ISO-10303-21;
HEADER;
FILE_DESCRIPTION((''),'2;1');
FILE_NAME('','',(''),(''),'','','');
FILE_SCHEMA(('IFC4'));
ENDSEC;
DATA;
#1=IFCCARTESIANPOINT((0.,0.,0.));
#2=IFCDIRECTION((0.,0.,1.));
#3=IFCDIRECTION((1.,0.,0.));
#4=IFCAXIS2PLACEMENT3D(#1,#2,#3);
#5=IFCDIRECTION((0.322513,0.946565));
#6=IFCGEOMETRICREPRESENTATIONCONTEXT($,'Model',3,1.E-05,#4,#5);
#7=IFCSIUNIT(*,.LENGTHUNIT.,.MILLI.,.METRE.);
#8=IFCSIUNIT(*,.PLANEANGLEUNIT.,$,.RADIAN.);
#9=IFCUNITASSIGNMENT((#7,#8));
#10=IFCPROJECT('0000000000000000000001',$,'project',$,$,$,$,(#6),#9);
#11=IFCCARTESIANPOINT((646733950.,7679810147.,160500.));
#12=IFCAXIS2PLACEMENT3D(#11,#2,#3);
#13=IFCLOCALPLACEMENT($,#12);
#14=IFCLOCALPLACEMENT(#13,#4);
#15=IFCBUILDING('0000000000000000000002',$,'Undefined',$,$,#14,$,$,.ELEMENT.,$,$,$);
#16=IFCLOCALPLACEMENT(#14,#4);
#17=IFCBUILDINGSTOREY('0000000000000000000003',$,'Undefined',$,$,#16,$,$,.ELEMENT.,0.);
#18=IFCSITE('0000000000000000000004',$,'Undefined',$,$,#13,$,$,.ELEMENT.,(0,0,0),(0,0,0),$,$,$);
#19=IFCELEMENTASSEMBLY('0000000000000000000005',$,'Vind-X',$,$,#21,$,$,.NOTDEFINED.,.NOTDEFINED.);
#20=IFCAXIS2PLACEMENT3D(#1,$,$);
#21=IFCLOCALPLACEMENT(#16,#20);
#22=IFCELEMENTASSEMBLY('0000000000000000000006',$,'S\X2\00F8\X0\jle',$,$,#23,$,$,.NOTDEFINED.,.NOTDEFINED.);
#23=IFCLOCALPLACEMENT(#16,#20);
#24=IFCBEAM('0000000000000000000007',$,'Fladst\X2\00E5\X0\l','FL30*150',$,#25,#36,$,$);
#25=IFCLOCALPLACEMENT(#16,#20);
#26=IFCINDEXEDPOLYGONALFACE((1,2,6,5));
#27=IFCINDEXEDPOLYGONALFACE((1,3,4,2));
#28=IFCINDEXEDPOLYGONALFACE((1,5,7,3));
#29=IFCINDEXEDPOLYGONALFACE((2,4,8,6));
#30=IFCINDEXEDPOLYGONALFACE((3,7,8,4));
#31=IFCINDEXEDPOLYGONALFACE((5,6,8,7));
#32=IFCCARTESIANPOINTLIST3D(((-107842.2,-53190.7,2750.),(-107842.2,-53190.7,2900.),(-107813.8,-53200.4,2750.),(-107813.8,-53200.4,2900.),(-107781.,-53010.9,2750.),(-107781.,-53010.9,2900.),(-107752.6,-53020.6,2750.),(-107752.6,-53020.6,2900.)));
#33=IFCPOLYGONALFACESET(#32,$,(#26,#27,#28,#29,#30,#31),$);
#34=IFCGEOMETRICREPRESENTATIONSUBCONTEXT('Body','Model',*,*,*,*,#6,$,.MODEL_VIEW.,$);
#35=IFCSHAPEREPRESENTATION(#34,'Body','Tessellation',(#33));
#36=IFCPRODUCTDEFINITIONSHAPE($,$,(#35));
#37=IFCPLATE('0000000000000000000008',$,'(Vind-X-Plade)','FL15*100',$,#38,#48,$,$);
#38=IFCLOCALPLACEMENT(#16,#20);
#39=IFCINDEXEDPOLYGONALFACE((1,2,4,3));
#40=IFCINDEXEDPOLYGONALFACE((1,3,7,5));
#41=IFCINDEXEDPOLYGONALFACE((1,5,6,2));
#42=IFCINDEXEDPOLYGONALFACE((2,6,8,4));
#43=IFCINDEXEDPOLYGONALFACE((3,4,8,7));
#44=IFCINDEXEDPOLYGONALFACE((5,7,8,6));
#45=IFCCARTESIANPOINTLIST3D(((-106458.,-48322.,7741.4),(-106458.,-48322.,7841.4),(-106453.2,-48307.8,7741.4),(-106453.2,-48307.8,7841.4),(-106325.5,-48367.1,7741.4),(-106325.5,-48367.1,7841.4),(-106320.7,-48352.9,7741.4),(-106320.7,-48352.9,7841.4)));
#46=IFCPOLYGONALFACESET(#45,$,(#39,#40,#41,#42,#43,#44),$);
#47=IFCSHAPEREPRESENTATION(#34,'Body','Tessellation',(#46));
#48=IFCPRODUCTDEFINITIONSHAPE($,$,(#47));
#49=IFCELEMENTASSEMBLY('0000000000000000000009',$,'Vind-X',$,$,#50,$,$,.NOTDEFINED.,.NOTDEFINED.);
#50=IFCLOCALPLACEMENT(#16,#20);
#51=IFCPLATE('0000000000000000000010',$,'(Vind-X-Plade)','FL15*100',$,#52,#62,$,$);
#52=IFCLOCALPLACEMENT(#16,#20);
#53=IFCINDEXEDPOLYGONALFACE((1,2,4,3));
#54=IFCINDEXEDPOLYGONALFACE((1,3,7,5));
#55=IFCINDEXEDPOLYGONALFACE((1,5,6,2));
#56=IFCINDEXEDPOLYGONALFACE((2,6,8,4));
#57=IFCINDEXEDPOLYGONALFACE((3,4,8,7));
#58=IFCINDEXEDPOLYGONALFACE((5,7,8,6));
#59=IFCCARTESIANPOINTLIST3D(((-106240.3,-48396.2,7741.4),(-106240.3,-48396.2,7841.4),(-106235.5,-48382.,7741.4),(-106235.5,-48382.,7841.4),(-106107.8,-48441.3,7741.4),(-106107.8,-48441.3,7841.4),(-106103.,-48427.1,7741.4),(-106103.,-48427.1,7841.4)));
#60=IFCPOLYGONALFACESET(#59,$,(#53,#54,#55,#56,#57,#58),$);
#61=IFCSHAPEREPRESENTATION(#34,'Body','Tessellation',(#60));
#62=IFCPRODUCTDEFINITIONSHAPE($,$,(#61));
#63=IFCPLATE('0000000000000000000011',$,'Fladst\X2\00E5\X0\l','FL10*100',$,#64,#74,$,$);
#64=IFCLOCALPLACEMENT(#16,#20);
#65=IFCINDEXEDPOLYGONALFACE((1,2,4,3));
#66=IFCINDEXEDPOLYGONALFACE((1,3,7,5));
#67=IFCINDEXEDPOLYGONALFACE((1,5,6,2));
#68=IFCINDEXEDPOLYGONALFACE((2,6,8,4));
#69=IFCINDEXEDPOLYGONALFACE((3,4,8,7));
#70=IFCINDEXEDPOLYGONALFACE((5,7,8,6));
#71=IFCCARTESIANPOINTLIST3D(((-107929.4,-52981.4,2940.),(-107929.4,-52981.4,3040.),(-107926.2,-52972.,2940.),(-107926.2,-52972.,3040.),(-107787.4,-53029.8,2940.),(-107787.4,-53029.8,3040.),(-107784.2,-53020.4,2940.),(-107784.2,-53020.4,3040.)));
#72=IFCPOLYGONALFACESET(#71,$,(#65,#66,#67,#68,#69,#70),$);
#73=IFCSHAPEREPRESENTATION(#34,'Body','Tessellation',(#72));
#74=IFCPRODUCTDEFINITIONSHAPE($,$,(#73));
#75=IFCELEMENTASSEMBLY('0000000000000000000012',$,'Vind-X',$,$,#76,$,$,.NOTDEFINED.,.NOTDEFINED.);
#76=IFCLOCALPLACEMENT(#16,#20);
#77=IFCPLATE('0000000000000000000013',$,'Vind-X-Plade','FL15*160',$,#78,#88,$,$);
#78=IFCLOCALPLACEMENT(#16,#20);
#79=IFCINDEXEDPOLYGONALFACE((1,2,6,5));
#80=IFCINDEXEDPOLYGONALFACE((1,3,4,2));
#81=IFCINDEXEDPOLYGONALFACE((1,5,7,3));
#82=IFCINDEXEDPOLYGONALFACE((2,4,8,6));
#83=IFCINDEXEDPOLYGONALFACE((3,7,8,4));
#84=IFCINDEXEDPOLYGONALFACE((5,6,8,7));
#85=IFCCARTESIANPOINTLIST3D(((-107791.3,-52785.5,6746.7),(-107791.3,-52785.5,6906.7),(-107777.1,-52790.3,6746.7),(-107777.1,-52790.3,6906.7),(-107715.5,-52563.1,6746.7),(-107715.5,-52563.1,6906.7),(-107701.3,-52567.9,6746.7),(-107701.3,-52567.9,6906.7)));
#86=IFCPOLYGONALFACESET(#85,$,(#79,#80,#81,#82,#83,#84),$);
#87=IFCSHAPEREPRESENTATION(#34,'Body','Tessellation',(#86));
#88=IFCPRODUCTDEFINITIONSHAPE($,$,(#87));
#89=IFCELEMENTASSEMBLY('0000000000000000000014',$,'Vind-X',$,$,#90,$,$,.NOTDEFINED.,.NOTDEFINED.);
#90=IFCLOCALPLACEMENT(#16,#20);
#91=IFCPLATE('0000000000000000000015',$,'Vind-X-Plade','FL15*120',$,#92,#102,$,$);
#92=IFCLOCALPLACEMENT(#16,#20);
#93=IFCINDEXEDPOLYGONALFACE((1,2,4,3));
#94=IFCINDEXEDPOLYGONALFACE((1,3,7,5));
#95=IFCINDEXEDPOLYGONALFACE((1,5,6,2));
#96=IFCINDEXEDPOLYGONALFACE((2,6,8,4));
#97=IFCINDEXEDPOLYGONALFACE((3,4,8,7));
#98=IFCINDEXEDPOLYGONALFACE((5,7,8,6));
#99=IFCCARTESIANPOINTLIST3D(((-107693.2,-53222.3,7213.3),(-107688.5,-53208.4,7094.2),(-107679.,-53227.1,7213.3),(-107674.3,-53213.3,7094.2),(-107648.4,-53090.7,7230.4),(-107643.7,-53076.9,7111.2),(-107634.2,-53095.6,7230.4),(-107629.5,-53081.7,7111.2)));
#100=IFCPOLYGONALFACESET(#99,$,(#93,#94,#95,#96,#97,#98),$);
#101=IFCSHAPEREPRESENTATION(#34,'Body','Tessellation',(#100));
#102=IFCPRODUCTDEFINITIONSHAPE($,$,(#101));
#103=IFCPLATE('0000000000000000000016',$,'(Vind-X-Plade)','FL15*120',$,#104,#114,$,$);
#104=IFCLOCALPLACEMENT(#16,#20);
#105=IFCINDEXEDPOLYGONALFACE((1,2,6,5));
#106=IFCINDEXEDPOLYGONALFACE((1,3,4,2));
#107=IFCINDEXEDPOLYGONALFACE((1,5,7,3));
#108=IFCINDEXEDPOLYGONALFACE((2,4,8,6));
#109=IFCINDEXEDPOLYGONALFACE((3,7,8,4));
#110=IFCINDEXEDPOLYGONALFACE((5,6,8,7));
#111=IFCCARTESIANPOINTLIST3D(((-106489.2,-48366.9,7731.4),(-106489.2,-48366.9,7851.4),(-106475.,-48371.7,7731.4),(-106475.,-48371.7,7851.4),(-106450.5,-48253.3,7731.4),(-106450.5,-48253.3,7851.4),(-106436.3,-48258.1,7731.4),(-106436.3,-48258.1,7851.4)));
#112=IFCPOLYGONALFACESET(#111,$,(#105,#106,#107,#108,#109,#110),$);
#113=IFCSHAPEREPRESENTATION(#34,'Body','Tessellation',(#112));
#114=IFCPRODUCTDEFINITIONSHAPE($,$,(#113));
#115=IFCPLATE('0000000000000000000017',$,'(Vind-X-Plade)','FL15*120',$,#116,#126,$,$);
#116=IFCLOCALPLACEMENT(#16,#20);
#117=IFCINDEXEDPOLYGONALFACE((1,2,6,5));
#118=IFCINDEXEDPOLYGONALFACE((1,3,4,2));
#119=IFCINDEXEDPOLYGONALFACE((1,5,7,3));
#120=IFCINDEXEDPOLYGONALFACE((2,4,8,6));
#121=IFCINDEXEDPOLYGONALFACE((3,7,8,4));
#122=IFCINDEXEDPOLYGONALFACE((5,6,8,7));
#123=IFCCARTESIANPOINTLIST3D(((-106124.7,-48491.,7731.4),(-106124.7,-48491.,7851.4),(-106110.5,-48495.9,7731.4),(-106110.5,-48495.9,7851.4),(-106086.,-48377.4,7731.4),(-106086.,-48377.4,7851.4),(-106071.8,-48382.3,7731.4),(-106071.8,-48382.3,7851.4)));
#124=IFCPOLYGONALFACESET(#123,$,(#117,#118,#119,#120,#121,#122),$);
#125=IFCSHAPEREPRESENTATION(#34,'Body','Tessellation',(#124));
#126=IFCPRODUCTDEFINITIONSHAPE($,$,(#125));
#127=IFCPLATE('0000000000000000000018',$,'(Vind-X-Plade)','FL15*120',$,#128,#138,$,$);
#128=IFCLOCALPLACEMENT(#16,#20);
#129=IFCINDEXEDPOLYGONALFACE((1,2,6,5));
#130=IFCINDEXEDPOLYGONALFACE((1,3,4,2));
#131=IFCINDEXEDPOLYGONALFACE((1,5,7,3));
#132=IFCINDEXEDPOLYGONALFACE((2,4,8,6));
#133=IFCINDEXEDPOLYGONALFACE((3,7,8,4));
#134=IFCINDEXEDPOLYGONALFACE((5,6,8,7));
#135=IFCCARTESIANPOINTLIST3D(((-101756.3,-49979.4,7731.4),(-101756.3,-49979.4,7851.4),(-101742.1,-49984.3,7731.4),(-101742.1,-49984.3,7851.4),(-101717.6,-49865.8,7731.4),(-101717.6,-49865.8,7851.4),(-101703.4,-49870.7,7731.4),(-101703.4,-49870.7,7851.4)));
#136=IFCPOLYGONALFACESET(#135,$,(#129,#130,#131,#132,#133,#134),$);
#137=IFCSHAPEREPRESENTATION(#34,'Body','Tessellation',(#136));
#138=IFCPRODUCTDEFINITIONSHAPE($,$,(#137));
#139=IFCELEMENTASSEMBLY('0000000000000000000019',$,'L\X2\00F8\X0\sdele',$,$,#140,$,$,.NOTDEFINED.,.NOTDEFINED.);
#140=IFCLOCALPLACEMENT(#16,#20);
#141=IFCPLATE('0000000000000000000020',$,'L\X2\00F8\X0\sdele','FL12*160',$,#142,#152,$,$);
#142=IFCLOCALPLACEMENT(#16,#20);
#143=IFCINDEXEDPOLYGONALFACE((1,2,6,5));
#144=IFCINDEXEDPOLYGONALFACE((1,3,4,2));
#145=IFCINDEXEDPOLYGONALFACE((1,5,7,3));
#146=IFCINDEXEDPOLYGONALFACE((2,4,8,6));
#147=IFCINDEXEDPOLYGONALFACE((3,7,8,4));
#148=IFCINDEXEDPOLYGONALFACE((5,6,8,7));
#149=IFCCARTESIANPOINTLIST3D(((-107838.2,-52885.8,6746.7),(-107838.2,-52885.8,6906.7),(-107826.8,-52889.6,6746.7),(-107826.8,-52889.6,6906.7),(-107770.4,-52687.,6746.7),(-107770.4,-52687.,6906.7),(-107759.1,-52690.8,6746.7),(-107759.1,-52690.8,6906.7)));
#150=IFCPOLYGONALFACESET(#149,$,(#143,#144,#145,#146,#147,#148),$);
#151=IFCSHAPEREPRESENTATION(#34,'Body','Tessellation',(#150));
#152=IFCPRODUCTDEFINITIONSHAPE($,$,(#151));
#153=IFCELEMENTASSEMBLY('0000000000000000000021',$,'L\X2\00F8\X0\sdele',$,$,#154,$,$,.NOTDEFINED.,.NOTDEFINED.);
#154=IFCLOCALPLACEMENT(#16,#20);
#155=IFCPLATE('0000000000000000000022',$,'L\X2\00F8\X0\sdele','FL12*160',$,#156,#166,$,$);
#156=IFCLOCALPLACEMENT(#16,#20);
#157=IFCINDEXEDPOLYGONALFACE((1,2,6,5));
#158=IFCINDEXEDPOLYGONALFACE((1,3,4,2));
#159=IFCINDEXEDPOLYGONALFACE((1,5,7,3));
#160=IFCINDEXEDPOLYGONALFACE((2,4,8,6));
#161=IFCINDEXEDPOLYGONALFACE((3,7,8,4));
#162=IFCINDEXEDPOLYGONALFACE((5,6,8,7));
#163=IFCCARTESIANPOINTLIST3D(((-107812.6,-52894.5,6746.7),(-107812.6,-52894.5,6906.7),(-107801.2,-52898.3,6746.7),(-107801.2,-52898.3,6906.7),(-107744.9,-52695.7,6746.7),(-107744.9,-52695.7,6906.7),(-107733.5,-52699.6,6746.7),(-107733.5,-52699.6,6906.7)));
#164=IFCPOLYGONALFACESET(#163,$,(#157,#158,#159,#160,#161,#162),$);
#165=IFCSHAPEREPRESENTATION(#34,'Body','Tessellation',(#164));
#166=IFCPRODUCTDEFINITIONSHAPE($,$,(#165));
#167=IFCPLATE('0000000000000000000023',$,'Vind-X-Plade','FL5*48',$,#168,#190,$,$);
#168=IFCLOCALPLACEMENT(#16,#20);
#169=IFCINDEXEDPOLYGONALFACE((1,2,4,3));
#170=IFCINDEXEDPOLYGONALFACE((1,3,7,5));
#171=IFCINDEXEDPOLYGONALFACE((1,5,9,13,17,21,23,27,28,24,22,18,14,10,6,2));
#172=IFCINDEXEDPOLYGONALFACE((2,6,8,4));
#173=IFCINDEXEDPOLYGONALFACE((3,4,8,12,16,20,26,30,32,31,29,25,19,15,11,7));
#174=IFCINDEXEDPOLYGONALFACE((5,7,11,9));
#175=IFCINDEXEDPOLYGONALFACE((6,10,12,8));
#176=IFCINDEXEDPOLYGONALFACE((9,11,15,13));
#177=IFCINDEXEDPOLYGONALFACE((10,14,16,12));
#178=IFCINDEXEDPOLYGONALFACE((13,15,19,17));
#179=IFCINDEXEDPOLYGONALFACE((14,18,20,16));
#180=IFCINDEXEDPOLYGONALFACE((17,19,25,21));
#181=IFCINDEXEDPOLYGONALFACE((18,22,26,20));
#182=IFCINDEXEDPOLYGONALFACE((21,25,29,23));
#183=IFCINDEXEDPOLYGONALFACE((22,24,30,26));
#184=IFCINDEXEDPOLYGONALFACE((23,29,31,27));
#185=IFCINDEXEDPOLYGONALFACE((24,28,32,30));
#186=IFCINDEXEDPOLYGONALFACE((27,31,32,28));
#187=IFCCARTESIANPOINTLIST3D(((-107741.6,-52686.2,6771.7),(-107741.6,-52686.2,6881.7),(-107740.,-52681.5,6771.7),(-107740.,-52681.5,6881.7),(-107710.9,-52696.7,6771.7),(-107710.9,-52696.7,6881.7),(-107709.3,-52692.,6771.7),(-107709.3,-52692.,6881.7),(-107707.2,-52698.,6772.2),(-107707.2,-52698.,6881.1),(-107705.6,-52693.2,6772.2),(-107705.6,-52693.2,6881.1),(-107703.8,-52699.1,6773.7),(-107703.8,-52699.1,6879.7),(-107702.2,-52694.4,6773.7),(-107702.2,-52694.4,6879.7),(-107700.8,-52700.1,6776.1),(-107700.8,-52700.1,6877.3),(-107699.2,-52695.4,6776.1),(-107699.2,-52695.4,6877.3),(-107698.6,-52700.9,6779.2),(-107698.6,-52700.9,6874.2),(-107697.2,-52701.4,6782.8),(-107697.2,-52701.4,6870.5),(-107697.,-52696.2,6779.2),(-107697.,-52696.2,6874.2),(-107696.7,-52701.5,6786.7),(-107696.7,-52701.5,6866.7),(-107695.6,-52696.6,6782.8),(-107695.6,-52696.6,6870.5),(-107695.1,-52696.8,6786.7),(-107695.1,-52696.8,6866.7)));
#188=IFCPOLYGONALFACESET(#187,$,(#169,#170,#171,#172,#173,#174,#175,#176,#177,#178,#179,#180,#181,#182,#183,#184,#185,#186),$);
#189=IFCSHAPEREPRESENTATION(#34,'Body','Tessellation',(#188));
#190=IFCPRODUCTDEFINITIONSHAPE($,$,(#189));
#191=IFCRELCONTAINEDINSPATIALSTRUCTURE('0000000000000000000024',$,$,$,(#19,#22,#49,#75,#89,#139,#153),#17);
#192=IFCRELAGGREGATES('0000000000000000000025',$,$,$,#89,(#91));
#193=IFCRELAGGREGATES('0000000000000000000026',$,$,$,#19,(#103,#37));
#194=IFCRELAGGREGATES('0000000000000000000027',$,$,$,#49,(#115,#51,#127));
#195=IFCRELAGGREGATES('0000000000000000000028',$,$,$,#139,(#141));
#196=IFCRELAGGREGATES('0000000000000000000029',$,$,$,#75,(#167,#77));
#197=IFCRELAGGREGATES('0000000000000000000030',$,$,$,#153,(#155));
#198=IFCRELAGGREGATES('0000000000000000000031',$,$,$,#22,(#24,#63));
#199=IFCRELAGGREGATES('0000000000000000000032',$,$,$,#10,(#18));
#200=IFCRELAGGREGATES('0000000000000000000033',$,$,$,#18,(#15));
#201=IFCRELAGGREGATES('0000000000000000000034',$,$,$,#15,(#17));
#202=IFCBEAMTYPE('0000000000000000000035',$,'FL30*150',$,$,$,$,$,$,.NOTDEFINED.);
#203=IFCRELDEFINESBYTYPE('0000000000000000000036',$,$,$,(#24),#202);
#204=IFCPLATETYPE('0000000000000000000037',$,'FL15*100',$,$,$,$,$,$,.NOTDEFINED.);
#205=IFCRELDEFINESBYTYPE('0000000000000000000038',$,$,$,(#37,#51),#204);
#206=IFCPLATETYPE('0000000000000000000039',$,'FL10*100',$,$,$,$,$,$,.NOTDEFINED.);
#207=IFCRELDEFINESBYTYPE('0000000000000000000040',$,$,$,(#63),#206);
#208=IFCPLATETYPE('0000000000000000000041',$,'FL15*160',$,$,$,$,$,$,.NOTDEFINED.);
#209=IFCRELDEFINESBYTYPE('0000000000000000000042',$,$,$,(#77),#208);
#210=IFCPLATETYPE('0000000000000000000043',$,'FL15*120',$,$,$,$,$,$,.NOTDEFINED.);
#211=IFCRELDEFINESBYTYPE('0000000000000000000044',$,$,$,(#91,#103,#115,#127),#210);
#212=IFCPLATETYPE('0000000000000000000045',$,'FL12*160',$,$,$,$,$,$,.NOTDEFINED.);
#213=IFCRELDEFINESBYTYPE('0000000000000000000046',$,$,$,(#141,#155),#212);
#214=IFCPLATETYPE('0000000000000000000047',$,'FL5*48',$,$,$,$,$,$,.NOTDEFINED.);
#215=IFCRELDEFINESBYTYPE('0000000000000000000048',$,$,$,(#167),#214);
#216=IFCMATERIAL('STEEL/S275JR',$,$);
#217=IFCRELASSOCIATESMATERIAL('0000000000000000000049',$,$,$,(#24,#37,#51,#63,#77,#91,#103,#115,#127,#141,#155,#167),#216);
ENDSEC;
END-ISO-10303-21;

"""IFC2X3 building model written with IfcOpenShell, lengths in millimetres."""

from ifc_helpers import new_model, si_unit, direction, frame, frame_2d, origin_with_axes, origin_2d_with_axis, place, context, subcontext, project, spatial, polyline, circle_curve, parameter, trimmed, segment, composite_curve, rectangle, outline, extrude, material, type_object, element, aggregate, save


model = new_model("IFC2X3")

# Units and contexts
model_context = context("Model", 3, precision=1e-05, world=origin_with_axes(), true_north=direction((0.322513, 0.946565)))
body_context = subcontext(model_context, "Body", "Model", "MODEL_VIEW")
ifc_project = project(units=[si_unit("LENGTHUNIT", "METRE", prefix="MILLI"), si_unit("PLANEANGLEUNIT", "RADIAN")], contexts=[model_context])

# Site, building, storey
site_placement = place(None, frame((646733950.0, 7679810147.0, 160500.0), z_axis=(0.0, 0.0, 1.0), x_axis=(1.0, 0.0, 0.0)))
site = spatial("IfcSite", under=ifc_project, at=site_placement, Name="Undefined", CompositionType="ELEMENT", RefLatitude=(0, 0, 0), RefLongitude=(0, 0, 0))
building_placement = place(site_placement, origin_with_axes())
building = spatial("IfcBuilding", under=site, at=building_placement, Name="Undefined", CompositionType="ELEMENT")
storey_placement = place(building_placement, origin_with_axes())
storey = spatial("IfcBuildingStorey", under=building, at=storey_placement, Name="Undefined", CompositionType="ELEMENT", Elevation=0.0)

# Element assemblies, beam
assembly_1_placement = place(storey_placement, origin_with_axes())
assembly_1 = element("IfcElementAssembly", 1, at=assembly_1_placement, inside=storey, Name="Vind-X", AssemblyPlace="NOTDEFINED", PredefinedType="NOTDEFINED")
assembly_2_placement = place(storey_placement, origin_with_axes())
assembly_2 = element("IfcElementAssembly", 2, at=assembly_2_placement, inside=storey, Name="Søjle", AssemblyPlace="NOTDEFINED", PredefinedType="NOTDEFINED")
ifc_material_1 = material(Name="STEEL/S275JR")
beam_type_1 = type_object("IfcBeamType", Name="FL30*150", PredefinedType="NOTDEFINED")
beam_1_placement = place(assembly_2_placement, frame((-107797.4, -53105.6, 2900.0), z_axis=(-0.322513, -0.946565, 0.0), x_axis=(0.0, 0.0, -1.0)))
beam_1 = element("IfcBeam", 3, at=beam_1_placement, type_object=beam_type_1, material=ifc_material_1, Name="Fladstål", Description="FL30*150", context=body_context, shape_type="SweptSolid", body=[
    extrude(rectangle(XDim=30.0, YDim=190.0, at=origin_2d_with_axis()), frame((150.0, 0.0, 0.0), z_axis=(-1.0, 0.0, 0.0), x_axis=(0.0, -1.0, 0.0)), (0.0, 0.0, 1.0), 150.0),
])

# Plate
plate_type_1 = type_object("IfcPlateType", Name="FL15*100", PredefinedType="NOTDEFINED")
plate_1_placement = place(assembly_1_placement, frame((-106323.1, -48360.0, 7741.4), z_axis=(-0.322513, -0.946565, 0.0), x_axis=(0.0, 0.0, 1.0)))
plate_1 = element("IfcPlate", 4, at=plate_1_placement, type_object=plate_type_1, material=ifc_material_1, Name="(Vind-X-Plade)", Description="FL15*100", context=body_context, shape_type="SweptSolid", body=[
    extrude(outline(polyline([(0.0, 0.0), (100.0, 0.0), (100.0, 140.0), (0.0, 140.0), (0.0, 0.0)])), frame((0.0, 0.0, -7.5), z_axis=(0.0, 0.0, 1.0), x_axis=(1.0, 0.0, 0.0)), (0.0, 0.0, 1.0), 15.0),
])

# Element assembly, plate
assembly_3_placement = place(storey_placement, origin_with_axes())
assembly_3 = element("IfcElementAssembly", 5, at=assembly_3_placement, inside=storey, Name="Vind-X", AssemblyPlace="NOTDEFINED", PredefinedType="NOTDEFINED")
plate_2_placement = place(assembly_3_placement, frame((-106237.9, -48389.1, 7741.4), z_axis=(0.322513, 0.946565, 0.0), x_axis=(0.0, 0.0, 1.0)))
plate_2 = element("IfcPlate", 6, at=plate_2_placement, type_object=plate_type_1, material=ifc_material_1, Name="(Vind-X-Plade)", Description="FL15*100", context=body_context, shape_type="SweptSolid", body=[
    extrude(outline(polyline([(0.0, 0.0), (100.0, 0.0), (100.0, 140.0), (0.0, 140.0), (0.0, 0.0)])), frame((0.0, 0.0, -7.5), z_axis=(0.0, 0.0, 1.0), x_axis=(1.0, 0.0, 0.0)), (0.0, 0.0, 1.0), 15.0),
])

# Plate
plate_type_2 = type_object("IfcPlateType", Name="FL10*100", PredefinedType="NOTDEFINED")
plate_3_placement = place(assembly_2_placement, frame((-107785.8, -53025.1, 3040.0), z_axis=(-0.322513, -0.946565, 0.0), x_axis=(-0.946565, 0.322513, 0.0)))
plate_3 = element("IfcPlate", 7, at=plate_3_placement, type_object=plate_type_2, material=ifc_material_1, Name="Fladstål", Description="FL10*100", context=body_context, shape_type="SweptSolid", body=[
    extrude(outline(polyline([(0.0, 0.0), (150.0, 0.0), (150.0, 100.0), (0.0, 100.0), (0.0, 0.0)])), frame((0.0, 0.0, -5.0), z_axis=(0.0, 0.0, 1.0), x_axis=(1.0, 0.0, 0.0)), (0.0, 0.0, 1.0), 10.0),
])

# Element assemblies, plates
assembly_4_placement = place(storey_placement, origin_with_axes())
assembly_4 = element("IfcElementAssembly", 8, at=assembly_4_placement, inside=storey, Name="Vind-X", AssemblyPlace="NOTDEFINED", PredefinedType="NOTDEFINED")
plate_type_3 = type_object("IfcPlateType", Name="FL15*160", PredefinedType="NOTDEFINED")
plate_4_placement = place(assembly_4_placement, frame((-107784.2, -52787.9, 6826.7), z_axis=(0.946565, -0.322513, 0.0), x_axis=(0.322513, 0.946565, 0.0)))
plate_4 = element("IfcPlate", 9, at=plate_4_placement, type_object=plate_type_3, material=ifc_material_1, Name="Vind-X-Plade", Description="FL15*160", context=body_context, shape_type="SweptSolid", body=[
    extrude(outline(polyline([(0.0, -80.0), (0.0, 80.0), (235.0, 80.0), (235.0, -80.0), (0.0, -80.0)])), frame((0.0, 0.0, -7.5), z_axis=(0.0, 0.0, 1.0), x_axis=(1.0, 0.0, 0.0)), (0.0, 0.0, 1.0), 15.0),
])
assembly_5_placement = place(storey_placement, origin_with_axes())
assembly_5 = element("IfcElementAssembly", 10, at=assembly_5_placement, inside=storey, Name="Vind-X", AssemblyPlace="NOTDEFINED", PredefinedType="NOTDEFINED")
plate_type_4 = type_object("IfcPlateType", Name="FL15*120", PredefinedType="NOTDEFINED")
plate_5_placement = place(assembly_5_placement, frame((-107636.6, -53079.3, 7111.2), z_axis=(-0.946565, 0.322513, -0.000007), x_axis=(-0.320109, -0.93951, -0.121869)))
plate_5 = element("IfcPlate", 11, at=plate_5_placement, type_object=plate_type_4, material=ifc_material_1, Name="Vind-X-Plade", Description="FL15*120", context=body_context, shape_type="SweptSolid", body=[
    extrude(outline(polyline([(0.0, 0.0), (140.0, 0.0), (140.0, 120.0), (0.0, 120.0), (0.0, 0.0)])), frame((0.0, 0.0, -7.5), z_axis=(0.0, 0.0, 1.0), x_axis=(1.0, 0.0, 0.0)), (0.0, 0.0, 1.0), 15.0),
])
aggregate(assembly_5, [plate_5])

# Plates
plate_6_placement = place(assembly_1_placement, frame((-106443.4, -48255.7, 7851.4), z_axis=(0.946565, -0.322513, 0.0), x_axis=(-0.322513, -0.946565, 0.0)))
plate_6 = element("IfcPlate", 12, at=plate_6_placement, type_object=plate_type_4, material=ifc_material_1, Name="(Vind-X-Plade)", Description="FL15*120", context=body_context, shape_type="SweptSolid", body=[
    extrude(outline(polyline([(0.0, 0.0), (120.0, 0.0), (120.0, 120.0), (0.0, 120.0), (0.0, 0.0)])), frame((0.0, 0.0, -7.5), z_axis=(0.0, 0.0, 1.0), x_axis=(1.0, 0.0, 0.0)), (0.0, 0.0, 1.0), 15.0),
])
aggregate(assembly_1, [plate_6, plate_1])
plate_7_placement = place(assembly_3_placement, frame((-106117.6, -48493.4, 7851.4), z_axis=(-0.946565, 0.322513, 0.0), x_axis=(0.322513, 0.946565, 0.0)))
plate_7 = element("IfcPlate", 13, at=plate_7_placement, type_object=plate_type_4, material=ifc_material_1, Name="(Vind-X-Plade)", Description="FL15*120", context=body_context, shape_type="SweptSolid", body=[
    extrude(outline(polyline([(0.0, 0.0), (120.0, 0.0), (120.0, 120.0), (0.0, 120.0), (0.0, 0.0)])), frame((0.0, 0.0, -7.5), z_axis=(0.0, 0.0, 1.0), x_axis=(1.0, 0.0, 0.0)), (0.0, 0.0, 1.0), 15.0),
])
plate_8_placement = place(assembly_3_placement, frame((-101710.5, -49868.2, 7851.4), z_axis=(0.946565, -0.322513, 0.0), x_axis=(-0.322513, -0.946565, 0.0)))
plate_8 = element("IfcPlate", 14, at=plate_8_placement, type_object=plate_type_4, material=ifc_material_1, Name="(Vind-X-Plade)", Description="FL15*120", context=body_context, shape_type="SweptSolid", body=[
    extrude(outline(polyline([(0.0, 0.0), (120.0, 0.0), (120.0, 120.0), (0.0, 120.0), (0.0, 0.0)])), frame((0.0, 0.0, -7.5), z_axis=(0.0, 0.0, 1.0), x_axis=(1.0, 0.0, 0.0)), (0.0, 0.0, 1.0), 15.0),
])
aggregate(assembly_3, [plate_7, plate_2, plate_8])

# Element assemblies, plates
assembly_6_placement = place(storey_placement, origin_with_axes())
assembly_6 = element("IfcElementAssembly", 15, at=assembly_6_placement, inside=storey, Name="Løsdele", AssemblyPlace="NOTDEFINED", PredefinedType="NOTDEFINED")
plate_type_5 = type_object("IfcPlateType", Name="FL12*160", PredefinedType="NOTDEFINED")
plate_9_placement = place(assembly_6_placement, frame((-107832.5, -52887.7, 6826.7), z_axis=(-0.946565, 0.322513, 0.0), x_axis=(0.322513, 0.946565, 0.0)))
plate_9 = element("IfcPlate", 16, at=plate_9_placement, type_object=plate_type_5, material=ifc_material_1, Name="Løsdele", Description="FL12*160", context=body_context, shape_type="SweptSolid", body=[
    extrude(outline(polyline([(0.0, -80.0), (0.0, 80.0), (210.0, 80.0), (210.0, -80.0), (0.0, -80.0)])), frame((0.0, 0.0, -6.0), z_axis=(0.0, 0.0, 1.0), x_axis=(1.0, 0.0, 0.0)), (0.0, 0.0, 1.0), 12.0),
])
aggregate(assembly_6, [plate_9])
assembly_7_placement = place(storey_placement, origin_with_axes())
assembly_7 = element("IfcElementAssembly", 17, at=assembly_7_placement, inside=storey, Name="Løsdele", AssemblyPlace="NOTDEFINED", PredefinedType="NOTDEFINED")
plate_10_placement = place(assembly_7_placement, frame((-107806.9, -52896.4, 6826.7), z_axis=(-0.946565, 0.322513, 0.0), x_axis=(0.322513, 0.946565, 0.0)))
plate_10 = element("IfcPlate", 18, at=plate_10_placement, type_object=plate_type_5, material=ifc_material_1, Name="Løsdele", Description="FL12*160", context=body_context, shape_type="SweptSolid", body=[
    extrude(outline(polyline([(0.0, -80.0), (0.0, 80.0), (210.0, 80.0), (210.0, -80.0), (0.0, -80.0)])), frame((0.0, 0.0, -6.0), z_axis=(0.0, 0.0, 1.0), x_axis=(1.0, 0.0, 0.0)), (0.0, 0.0, 1.0), 12.0),
])

# Plate
plate_type_6 = type_object("IfcPlateType", Name="FL5*48", PredefinedType="NOTDEFINED")
plate_11_placement = place(assembly_4_placement, frame((-107695.9, -52699.2, 6771.7), z_axis=(0.322513, 0.946565, 0.0), x_axis=(-0.946565, 0.322513, 0.0)))
plate_11 = element("IfcPlate", 19, at=plate_11_placement, type_object=plate_type_6, material=ifc_material_1, Name="Vind-X-Plade", Description="FL5*48", context=body_context, shape_type="SweptSolid", body=[
    extrude(outline(composite_curve([segment(trimmed(circle_curve(frame_2d((15.0, 15.0), x_axis=(-1.0, 0.0)), 15.0), [parameter(0.0)], [parameter(1.570796)], True, "PARAMETER"), True, "CONTINUOUS"), segment(polyline([(15.0, 0.0), (47.5, 0.0), (47.5, 110.0), (15.0, 110.0)]), True, "CONTINUOUS"), segment(trimmed(circle_curve(frame_2d((15.0, 95.0), x_axis=(0.0, 1.0)), 15.0), [parameter(0.0)], [parameter(1.570796)], True, "PARAMETER"), True, "CONTINUOUS"), segment(polyline([(0.0, 95.0), (0.0, 15.0)]), True, "CONTINUOUS")], self_intersect=True)), frame((0.0, 0.0, -2.5), z_axis=(0.0, 0.0, 1.0), x_axis=(1.0, 0.0, 0.0)), (0.0, 0.0, 1.0), 5.0),
])
aggregate(assembly_4, [plate_11, plate_4])

aggregate(assembly_7, [plate_10])

aggregate(assembly_2, [beam_1, plate_3])

save(model, "model.ifc")
